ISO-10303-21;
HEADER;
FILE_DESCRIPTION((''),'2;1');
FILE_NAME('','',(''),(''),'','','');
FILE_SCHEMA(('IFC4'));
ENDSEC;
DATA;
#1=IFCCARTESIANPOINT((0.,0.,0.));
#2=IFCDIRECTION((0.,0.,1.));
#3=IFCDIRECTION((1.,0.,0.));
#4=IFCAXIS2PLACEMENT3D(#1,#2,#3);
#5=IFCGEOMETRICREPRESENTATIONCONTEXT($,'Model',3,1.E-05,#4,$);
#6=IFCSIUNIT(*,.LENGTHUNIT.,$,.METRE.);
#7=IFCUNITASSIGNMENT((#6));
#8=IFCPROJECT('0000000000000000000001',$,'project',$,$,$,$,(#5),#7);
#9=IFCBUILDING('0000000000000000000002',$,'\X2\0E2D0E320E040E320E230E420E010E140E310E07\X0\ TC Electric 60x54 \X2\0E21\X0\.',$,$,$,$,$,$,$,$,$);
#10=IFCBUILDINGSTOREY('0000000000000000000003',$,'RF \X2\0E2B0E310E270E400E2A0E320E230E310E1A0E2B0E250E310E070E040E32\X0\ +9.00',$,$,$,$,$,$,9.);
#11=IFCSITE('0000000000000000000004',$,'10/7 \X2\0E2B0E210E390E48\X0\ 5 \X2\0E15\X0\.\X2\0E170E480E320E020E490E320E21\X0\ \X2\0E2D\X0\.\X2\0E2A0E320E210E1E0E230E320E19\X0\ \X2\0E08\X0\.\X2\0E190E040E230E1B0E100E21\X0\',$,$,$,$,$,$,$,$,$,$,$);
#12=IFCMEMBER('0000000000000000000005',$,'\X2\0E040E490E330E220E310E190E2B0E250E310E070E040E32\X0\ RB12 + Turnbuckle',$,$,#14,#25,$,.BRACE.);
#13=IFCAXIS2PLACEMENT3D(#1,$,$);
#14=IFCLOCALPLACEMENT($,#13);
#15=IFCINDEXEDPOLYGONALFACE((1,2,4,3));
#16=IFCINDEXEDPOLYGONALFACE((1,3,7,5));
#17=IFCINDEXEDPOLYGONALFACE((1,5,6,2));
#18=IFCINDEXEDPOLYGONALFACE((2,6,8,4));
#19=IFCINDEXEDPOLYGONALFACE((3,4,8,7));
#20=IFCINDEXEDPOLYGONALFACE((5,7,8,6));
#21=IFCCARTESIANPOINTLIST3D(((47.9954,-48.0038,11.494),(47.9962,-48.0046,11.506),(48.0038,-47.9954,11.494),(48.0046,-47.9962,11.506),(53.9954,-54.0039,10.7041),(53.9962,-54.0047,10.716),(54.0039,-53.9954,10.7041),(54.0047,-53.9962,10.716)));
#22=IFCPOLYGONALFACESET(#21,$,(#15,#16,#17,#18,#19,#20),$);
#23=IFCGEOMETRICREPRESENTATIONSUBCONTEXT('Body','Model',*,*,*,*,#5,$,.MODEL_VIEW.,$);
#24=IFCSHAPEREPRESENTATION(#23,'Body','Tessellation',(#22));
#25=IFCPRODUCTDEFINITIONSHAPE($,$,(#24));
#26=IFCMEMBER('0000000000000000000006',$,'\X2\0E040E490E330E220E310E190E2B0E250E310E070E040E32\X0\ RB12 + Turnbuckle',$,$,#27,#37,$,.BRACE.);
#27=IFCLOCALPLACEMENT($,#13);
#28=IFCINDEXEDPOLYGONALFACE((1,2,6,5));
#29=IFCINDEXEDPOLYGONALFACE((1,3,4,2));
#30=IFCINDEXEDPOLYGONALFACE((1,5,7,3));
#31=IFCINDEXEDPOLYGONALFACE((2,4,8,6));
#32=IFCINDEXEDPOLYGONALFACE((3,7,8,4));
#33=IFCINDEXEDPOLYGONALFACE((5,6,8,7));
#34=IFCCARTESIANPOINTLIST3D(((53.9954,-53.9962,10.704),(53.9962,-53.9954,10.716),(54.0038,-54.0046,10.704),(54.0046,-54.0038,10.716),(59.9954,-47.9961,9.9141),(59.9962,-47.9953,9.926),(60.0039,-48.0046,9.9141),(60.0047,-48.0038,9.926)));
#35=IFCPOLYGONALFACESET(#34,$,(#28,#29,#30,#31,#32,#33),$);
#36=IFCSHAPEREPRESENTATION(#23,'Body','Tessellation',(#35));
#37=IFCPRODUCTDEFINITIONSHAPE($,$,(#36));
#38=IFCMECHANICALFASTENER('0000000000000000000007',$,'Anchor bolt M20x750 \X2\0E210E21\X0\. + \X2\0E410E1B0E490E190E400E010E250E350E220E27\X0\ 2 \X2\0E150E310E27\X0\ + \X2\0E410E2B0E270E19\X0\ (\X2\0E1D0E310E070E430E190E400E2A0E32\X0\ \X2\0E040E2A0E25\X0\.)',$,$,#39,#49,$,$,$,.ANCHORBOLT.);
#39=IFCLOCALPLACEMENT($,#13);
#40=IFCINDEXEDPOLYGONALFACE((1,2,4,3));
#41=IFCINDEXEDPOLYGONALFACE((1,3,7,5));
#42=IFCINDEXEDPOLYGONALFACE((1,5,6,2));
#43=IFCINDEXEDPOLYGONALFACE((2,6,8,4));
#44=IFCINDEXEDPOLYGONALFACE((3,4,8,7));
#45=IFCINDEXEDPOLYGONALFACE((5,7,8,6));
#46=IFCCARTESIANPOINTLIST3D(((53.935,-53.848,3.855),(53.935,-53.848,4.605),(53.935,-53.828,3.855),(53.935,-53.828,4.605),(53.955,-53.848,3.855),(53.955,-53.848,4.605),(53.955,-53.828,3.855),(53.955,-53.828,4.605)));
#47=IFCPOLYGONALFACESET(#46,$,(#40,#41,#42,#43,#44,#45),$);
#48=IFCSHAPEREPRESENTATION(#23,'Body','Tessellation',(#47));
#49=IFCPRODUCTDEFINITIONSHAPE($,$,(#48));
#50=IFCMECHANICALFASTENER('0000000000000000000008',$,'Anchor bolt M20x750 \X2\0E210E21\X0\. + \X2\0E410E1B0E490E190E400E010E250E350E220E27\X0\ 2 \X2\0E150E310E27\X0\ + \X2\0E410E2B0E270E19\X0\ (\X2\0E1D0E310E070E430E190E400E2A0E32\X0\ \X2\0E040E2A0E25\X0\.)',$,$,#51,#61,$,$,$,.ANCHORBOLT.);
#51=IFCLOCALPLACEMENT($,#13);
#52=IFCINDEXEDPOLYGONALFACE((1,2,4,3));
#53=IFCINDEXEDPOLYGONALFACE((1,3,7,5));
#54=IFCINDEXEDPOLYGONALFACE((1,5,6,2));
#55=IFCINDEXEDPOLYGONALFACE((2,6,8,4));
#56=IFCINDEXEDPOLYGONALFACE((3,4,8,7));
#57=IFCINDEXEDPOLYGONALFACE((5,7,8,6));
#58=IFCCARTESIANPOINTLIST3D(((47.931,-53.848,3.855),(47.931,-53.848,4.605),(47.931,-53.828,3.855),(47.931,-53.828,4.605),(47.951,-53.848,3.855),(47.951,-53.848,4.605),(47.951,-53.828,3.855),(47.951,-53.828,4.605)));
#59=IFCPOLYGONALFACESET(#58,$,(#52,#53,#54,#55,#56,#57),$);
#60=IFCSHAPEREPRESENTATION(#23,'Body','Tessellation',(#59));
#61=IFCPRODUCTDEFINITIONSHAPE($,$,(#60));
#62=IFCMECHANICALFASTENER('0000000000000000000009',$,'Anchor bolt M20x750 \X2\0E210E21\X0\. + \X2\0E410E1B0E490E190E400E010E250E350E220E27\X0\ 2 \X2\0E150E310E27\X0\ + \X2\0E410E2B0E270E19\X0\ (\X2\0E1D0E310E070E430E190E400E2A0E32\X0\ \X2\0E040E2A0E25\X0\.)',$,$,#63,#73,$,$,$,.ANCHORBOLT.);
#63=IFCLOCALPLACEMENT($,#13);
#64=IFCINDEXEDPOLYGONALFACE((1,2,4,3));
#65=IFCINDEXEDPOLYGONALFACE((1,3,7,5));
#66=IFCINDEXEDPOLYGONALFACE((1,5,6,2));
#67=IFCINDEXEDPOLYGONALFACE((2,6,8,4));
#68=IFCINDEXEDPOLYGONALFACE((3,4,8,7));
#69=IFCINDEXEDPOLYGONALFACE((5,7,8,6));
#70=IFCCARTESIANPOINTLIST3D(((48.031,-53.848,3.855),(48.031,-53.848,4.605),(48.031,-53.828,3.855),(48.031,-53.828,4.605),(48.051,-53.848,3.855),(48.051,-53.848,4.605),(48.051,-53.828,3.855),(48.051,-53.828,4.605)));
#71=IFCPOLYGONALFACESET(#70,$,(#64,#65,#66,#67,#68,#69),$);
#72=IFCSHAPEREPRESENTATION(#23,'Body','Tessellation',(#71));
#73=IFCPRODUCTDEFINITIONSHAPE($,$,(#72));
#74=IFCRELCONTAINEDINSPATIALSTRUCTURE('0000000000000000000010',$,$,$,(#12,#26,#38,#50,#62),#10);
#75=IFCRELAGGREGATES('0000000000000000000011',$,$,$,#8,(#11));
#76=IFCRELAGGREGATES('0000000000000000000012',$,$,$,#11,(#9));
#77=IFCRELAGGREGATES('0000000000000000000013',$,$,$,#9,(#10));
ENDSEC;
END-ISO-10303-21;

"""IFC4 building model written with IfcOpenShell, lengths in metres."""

from ifc_helpers import new_model, si_unit, frame, origin, origin_with_axes, origin_2d, place, context, subcontext, project, spatial, rectangle, extrude, element, save


model = new_model("IFC4")

# Units and contexts
model_context = context("Model", 3, precision=1e-05, world=origin_with_axes())
body_context = subcontext(model_context, "Body", "Model", "MODEL_VIEW")
ifc_project = project(units=[si_unit("LENGTHUNIT", "METRE")], contexts=[model_context])

# Site, building, storey
site = spatial("IfcSite", under=ifc_project, Name="10/7 หมู่ 5 ต.ท่าข้าม อ.สามพราน จ.นครปฐม")
building = spatial("IfcBuilding", under=site, Name="อาคารโกดัง TC Electric 60x54 ม.")
storey = spatial("IfcBuildingStorey", under=building, Name="RF หัวเสารับหลังคา +9.00", Elevation=9.0)

# Members
for number, where, z_axis, x_axis, name in (
    (1, (48.0, -48.0, 11.5), (0.7041, -0.7041, -0.0927), (-0.7071, -0.7071, 0.0), "ค้ำยันหลังคา RB12 + Turnbuckle"),
    (2, (54.0, -54.0, 10.71), (0.7041, 0.7041, -0.0927), (0.7071, -0.7071, 0.0), "ค้ำยันหลังคา RB12 + Turnbuckle"),
):
    element("IfcMember", number, at=place(None, frame(where, z_axis=z_axis, x_axis=x_axis)), inside=storey, Name=name, PredefinedType="BRACE", context=body_context, shape_type="SweptSolid", body=[
        extrude(rectangle(XDim=0.012, YDim=0.012, at=origin_2d()), origin(), (0.0, 0.0, 1.0), 8.522),
    ])

# Mechanical fasteners
for number, where, z_axis, x_axis, name in (
    (3, (53.945, -53.838, 3.855), (0.0, 0.0, 1.0), (1.0, 0.0, 0.0), "Anchor bolt M20x750 มม. + แป้นเกลียว 2 ตัว + แหวน (ฝังในเสา คสล.)"),
    (4, (47.941, -53.838, 3.855), (0.0, 0.0, 1.0), (1.0, 0.0, 0.0), "Anchor bolt M20x750 มม. + แป้นเกลียว 2 ตัว + แหวน (ฝังในเสา คสล.)"),
    (5, (48.041, -53.838, 3.855), (0.0, 0.0, 1.0), (1.0, 0.0, 0.0), "Anchor bolt M20x750 มม. + แป้นเกลียว 2 ตัว + แหวน (ฝังในเสา คสล.)"),
):
    element("IfcMechanicalFastener", number, at=place(None, frame(where, z_axis=z_axis, x_axis=x_axis)), inside=storey, Name=name, PredefinedType="ANCHORBOLT", context=body_context, shape_type="SweptSolid", body=[
        extrude(rectangle(XDim=0.02, YDim=0.02, at=origin_2d()), origin(), (0.0, 0.0, 1.0), 0.75),
    ])

save(model, "model.ifc")
